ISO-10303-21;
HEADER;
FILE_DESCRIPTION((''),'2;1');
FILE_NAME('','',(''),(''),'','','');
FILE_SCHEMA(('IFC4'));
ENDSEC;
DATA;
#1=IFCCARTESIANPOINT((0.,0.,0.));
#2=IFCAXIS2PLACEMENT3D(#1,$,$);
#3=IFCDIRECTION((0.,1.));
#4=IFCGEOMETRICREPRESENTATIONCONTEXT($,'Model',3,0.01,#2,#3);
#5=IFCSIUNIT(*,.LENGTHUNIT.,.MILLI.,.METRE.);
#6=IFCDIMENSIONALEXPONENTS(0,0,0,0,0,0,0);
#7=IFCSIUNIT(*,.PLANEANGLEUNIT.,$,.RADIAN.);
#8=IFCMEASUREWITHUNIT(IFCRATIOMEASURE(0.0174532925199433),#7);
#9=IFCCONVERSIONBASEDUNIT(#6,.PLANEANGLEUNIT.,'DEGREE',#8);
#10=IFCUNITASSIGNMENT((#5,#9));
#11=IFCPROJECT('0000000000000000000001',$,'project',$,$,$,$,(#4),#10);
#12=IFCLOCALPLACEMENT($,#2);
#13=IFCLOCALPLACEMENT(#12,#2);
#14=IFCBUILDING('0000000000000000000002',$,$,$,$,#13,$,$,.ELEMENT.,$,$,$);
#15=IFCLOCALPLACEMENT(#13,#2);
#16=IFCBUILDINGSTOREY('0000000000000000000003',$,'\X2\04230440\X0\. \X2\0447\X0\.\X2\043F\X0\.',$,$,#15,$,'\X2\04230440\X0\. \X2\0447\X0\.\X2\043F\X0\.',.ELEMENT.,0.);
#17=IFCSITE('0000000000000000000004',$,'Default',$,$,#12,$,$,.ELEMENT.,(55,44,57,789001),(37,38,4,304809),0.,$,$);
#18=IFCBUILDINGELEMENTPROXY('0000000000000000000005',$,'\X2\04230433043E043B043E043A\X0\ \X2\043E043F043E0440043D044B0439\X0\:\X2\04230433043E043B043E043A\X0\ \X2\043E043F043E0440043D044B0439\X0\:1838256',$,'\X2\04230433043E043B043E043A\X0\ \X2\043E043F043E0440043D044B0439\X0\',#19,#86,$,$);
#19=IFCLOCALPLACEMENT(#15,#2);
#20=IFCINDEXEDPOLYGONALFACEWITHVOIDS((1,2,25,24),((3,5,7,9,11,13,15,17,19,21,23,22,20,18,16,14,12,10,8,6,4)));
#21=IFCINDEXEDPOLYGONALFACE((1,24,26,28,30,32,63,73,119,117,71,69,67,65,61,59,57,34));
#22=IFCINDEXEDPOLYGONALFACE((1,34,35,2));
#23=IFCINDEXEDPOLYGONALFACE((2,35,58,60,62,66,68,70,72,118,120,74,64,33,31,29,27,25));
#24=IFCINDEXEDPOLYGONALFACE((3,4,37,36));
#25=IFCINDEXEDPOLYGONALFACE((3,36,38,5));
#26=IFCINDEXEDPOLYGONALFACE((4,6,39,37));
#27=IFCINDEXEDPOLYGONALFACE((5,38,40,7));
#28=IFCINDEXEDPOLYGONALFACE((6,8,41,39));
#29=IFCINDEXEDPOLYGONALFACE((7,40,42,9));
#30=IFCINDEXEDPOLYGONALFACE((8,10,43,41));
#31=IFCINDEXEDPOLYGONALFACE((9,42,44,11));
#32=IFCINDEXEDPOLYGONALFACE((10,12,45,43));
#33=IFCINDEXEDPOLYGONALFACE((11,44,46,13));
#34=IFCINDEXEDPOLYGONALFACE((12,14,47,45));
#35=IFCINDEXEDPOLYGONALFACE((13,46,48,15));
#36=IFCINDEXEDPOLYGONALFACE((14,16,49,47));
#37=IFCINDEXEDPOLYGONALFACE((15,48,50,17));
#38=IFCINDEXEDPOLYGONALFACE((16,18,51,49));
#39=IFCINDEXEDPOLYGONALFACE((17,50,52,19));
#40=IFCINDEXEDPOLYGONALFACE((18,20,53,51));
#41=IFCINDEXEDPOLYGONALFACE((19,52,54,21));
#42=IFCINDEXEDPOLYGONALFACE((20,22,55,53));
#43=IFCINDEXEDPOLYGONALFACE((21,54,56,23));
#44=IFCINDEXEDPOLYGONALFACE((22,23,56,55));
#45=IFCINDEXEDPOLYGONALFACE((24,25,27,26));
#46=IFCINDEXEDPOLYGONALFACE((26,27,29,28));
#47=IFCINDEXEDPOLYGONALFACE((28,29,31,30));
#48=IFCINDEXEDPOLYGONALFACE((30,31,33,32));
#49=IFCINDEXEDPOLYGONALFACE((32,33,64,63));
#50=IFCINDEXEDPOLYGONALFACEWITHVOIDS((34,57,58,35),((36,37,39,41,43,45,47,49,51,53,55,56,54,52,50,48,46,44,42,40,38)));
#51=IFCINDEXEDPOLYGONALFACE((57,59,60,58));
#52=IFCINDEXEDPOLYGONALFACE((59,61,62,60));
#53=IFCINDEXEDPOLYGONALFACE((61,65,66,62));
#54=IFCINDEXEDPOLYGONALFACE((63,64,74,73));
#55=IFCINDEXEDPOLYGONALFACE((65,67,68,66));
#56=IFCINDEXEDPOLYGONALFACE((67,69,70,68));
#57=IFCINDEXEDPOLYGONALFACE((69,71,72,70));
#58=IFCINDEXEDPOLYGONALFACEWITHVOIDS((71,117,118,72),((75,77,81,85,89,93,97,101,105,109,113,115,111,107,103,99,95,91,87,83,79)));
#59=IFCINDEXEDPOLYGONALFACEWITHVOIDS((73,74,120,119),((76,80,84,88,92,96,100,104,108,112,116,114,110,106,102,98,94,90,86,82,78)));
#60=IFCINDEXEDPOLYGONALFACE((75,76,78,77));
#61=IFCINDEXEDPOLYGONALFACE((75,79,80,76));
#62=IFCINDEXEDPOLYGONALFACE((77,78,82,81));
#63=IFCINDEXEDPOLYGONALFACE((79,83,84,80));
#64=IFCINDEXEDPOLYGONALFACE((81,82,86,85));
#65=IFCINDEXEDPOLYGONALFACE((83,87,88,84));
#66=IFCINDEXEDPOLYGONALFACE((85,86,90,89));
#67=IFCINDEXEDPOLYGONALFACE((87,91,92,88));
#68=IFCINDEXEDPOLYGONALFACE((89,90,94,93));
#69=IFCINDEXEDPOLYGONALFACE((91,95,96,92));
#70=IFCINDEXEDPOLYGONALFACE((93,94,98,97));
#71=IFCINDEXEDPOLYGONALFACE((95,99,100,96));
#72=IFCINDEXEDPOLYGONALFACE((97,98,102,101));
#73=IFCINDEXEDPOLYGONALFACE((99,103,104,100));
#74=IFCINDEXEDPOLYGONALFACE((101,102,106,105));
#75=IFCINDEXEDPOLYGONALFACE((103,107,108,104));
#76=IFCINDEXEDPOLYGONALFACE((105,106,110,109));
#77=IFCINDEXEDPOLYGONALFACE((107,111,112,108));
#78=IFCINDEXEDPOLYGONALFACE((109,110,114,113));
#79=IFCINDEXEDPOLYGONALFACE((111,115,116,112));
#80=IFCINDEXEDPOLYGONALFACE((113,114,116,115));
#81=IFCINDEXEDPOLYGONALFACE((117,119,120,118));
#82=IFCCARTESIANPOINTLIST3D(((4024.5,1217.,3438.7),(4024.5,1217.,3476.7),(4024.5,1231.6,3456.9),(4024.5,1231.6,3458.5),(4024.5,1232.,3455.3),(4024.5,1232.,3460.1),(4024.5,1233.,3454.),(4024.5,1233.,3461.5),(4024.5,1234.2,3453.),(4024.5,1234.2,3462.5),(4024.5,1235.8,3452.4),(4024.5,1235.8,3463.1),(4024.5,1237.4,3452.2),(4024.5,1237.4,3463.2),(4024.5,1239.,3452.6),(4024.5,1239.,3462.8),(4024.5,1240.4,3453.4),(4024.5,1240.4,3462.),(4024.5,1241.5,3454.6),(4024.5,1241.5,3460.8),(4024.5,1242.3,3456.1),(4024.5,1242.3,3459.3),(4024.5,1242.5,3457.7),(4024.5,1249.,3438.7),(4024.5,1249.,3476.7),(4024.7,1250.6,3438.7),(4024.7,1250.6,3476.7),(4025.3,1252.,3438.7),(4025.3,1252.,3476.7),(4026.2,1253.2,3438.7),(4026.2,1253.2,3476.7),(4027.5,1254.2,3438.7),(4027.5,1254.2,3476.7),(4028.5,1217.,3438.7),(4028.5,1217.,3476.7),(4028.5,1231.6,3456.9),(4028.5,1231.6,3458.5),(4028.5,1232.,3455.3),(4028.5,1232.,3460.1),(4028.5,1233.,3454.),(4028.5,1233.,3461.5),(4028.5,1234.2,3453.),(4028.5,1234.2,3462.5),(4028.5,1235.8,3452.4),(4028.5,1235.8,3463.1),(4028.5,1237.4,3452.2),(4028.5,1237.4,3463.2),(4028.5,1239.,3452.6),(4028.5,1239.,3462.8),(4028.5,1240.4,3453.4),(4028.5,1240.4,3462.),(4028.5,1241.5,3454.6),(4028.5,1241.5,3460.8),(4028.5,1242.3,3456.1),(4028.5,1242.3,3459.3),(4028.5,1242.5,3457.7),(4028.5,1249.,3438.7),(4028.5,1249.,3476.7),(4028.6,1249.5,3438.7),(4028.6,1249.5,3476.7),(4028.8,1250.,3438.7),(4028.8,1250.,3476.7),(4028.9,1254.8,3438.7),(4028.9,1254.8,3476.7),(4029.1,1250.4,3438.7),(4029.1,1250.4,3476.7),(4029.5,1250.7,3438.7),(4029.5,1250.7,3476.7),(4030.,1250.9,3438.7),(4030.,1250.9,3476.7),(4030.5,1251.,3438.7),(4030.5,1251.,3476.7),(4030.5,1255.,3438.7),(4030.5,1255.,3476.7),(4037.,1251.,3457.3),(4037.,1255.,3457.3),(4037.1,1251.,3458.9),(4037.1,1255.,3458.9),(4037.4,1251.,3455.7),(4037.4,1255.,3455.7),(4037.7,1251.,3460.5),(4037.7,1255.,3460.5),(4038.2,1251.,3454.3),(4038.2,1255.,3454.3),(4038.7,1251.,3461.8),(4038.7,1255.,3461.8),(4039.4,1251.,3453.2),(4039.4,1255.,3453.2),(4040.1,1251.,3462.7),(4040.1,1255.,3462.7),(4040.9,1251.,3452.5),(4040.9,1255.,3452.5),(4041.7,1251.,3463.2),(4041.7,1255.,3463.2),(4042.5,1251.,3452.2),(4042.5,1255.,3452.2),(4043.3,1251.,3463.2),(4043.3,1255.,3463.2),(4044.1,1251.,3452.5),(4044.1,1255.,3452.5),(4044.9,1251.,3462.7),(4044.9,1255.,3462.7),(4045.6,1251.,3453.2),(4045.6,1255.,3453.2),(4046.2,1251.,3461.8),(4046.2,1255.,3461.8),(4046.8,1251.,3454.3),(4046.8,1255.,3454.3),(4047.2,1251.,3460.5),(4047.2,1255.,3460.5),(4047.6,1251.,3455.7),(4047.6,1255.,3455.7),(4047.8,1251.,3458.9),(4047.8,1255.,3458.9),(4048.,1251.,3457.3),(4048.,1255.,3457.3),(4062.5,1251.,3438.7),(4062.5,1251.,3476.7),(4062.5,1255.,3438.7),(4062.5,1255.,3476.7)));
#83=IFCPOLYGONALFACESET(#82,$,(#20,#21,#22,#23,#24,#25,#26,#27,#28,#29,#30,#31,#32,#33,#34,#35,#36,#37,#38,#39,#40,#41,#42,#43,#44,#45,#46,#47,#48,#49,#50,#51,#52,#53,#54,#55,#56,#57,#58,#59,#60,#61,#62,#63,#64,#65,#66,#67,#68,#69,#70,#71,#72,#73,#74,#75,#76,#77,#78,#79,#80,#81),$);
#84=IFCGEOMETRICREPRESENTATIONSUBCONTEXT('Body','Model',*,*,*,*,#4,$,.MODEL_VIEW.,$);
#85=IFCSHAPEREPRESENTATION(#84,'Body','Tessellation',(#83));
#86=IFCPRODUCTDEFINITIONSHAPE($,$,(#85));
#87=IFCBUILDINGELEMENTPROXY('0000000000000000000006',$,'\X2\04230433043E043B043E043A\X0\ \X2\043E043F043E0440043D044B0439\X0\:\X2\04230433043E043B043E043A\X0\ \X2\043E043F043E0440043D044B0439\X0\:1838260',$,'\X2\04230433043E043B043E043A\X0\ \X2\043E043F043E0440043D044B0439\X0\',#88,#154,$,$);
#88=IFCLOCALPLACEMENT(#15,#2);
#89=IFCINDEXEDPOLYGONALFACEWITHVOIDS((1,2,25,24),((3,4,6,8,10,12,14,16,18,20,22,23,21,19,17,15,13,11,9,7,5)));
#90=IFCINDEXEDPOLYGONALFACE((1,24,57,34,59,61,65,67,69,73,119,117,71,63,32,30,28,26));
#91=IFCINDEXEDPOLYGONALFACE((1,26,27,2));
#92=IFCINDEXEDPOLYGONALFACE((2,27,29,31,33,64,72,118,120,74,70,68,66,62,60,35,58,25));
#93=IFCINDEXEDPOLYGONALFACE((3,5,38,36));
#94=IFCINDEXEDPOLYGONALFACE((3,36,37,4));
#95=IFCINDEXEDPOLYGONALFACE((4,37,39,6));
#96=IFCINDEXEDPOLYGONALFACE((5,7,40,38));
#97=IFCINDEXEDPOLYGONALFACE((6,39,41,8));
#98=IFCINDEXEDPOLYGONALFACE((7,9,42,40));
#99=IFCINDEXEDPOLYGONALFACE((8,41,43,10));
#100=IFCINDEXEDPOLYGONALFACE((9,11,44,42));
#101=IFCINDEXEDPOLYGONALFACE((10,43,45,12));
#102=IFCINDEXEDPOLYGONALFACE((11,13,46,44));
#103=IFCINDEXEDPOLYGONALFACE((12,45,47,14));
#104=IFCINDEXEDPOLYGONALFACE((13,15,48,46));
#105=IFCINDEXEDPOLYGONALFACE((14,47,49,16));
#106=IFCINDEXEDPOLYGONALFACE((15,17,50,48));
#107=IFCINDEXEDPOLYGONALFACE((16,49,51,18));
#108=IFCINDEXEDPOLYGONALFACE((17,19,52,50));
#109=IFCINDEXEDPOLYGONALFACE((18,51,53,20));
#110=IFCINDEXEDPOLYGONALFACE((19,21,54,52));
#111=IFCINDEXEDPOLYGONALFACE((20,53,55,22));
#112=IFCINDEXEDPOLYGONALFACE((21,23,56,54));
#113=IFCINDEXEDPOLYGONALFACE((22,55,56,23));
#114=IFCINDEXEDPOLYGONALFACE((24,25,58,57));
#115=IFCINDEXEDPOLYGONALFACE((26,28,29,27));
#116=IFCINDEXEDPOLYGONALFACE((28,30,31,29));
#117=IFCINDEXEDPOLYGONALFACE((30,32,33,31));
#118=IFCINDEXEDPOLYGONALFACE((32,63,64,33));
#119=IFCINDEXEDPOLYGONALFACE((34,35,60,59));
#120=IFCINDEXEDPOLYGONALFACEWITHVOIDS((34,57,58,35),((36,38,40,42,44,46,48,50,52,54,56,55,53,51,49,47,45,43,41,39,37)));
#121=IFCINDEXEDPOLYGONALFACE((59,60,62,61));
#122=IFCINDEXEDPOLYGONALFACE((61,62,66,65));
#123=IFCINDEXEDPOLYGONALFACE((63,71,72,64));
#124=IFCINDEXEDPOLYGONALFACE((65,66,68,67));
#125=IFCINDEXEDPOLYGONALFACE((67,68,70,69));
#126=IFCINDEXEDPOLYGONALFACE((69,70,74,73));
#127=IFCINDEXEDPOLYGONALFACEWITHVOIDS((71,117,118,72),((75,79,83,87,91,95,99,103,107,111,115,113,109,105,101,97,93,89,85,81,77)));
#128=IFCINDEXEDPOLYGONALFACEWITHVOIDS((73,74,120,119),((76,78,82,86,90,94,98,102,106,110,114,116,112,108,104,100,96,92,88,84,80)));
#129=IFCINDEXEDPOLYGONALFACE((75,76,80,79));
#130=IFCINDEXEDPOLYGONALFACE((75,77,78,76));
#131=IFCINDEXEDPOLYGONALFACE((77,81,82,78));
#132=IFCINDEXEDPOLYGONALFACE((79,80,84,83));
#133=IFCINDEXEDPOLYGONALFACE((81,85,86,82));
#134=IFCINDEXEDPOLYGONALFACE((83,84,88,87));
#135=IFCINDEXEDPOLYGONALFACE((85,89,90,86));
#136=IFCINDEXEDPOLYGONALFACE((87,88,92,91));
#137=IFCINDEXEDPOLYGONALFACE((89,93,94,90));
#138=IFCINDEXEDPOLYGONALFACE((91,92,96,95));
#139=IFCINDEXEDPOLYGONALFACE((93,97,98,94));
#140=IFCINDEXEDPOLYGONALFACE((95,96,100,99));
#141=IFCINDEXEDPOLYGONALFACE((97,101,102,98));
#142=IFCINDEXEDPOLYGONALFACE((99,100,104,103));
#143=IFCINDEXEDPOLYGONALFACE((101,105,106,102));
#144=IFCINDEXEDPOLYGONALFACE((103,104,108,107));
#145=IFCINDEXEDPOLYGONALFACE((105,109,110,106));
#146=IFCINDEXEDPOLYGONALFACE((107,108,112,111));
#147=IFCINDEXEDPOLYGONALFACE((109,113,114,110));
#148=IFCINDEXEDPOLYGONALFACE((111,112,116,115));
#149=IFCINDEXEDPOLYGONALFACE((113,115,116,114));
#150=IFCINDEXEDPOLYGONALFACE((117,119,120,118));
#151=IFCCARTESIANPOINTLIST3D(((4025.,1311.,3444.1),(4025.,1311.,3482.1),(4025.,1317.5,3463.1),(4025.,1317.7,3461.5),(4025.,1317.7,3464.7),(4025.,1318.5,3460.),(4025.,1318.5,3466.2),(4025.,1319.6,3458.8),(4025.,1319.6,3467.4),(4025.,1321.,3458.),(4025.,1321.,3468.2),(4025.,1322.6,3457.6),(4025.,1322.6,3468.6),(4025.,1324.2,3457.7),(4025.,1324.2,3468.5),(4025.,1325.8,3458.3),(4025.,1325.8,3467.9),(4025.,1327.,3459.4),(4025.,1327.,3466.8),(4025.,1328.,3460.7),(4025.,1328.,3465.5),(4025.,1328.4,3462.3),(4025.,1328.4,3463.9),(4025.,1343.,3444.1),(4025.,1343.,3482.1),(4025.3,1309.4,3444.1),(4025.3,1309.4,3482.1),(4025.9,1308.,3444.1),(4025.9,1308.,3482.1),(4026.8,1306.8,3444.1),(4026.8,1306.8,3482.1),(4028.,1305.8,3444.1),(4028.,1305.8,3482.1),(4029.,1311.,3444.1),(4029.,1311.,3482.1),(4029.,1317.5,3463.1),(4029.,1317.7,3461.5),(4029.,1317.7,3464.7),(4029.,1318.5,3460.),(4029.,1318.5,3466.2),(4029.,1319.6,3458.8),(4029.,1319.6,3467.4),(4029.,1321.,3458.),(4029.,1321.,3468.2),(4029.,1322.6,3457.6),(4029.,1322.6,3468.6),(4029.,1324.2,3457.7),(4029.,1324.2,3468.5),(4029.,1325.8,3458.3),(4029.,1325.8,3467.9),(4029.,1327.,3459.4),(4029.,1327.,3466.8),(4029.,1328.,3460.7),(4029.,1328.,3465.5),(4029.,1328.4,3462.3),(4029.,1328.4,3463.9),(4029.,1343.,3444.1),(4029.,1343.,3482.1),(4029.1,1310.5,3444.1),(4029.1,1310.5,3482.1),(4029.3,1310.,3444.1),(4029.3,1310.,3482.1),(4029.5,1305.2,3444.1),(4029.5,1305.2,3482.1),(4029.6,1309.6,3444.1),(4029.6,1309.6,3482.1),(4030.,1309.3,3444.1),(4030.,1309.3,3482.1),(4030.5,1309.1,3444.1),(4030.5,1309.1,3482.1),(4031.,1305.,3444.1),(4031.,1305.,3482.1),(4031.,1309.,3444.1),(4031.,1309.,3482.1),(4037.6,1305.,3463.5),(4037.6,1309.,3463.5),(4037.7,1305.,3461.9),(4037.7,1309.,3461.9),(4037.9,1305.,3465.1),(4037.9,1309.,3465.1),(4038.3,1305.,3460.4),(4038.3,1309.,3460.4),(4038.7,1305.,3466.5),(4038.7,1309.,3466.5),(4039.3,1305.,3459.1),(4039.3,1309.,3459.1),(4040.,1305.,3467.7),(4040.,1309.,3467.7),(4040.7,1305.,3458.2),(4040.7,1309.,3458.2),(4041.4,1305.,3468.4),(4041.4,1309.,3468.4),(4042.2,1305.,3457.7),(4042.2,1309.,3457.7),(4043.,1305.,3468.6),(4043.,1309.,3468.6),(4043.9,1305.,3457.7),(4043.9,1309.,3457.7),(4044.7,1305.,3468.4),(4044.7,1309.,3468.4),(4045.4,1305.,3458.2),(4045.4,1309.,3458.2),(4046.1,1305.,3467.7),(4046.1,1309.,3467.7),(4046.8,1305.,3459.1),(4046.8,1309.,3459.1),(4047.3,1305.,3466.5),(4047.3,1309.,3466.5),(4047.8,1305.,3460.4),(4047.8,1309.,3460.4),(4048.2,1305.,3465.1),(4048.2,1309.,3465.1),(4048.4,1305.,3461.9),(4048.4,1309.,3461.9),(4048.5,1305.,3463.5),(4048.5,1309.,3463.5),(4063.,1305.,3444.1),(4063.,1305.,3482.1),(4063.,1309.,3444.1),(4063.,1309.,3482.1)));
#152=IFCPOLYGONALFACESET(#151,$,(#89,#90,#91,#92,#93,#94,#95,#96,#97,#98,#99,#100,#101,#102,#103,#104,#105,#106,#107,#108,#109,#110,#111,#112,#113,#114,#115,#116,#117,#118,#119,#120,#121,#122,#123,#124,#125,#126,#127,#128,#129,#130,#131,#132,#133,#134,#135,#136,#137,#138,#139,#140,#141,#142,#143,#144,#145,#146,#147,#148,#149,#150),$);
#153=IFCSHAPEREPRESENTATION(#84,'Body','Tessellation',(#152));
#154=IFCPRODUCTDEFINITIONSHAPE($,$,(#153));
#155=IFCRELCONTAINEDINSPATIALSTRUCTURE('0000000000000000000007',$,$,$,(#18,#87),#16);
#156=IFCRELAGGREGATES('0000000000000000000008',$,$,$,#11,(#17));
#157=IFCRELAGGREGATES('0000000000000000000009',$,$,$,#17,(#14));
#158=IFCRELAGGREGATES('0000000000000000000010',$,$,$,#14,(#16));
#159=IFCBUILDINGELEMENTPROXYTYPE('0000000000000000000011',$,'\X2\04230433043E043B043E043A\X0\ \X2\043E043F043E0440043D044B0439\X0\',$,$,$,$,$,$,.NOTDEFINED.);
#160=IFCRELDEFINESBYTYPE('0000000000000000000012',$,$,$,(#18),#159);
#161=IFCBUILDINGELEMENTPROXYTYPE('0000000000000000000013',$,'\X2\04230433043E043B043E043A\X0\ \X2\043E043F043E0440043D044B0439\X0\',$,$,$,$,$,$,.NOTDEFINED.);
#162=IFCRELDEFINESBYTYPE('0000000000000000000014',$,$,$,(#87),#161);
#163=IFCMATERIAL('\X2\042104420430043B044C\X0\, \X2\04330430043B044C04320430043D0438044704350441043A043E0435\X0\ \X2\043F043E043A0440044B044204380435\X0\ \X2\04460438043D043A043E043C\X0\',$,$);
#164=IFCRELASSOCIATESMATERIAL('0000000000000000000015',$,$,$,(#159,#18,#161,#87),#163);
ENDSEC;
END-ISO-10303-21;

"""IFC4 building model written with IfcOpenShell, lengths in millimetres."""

from ifc_helpers import new_model, entity, si_unit, converted_unit, direction, frame, frame_2d, origin, place, context, subcontext, project, spatial, polyline, circle_curve, parameter, trimmed, segment, composite_curve, circle, outline, extrude, source, transform, mapped, material, type_object, type_shapes, element, save


model = new_model("IFC4")

# Units and contexts
model_context = context("Model", 3, precision=0.01, world=origin(), true_north=direction((0.0, 1.0)))
body_context = subcontext(model_context, "Body", "Model", "MODEL_VIEW")
ifc_project = project(units=[si_unit("LENGTHUNIT", "METRE", prefix="MILLI"), converted_unit("PLANEANGLEUNIT", "DEGREE", entity("IfcRatioMeasure", 0.0174532925199433), si_unit("PLANEANGLEUNIT", "RADIAN"), dimensions=[0, 0, 0, 0, 0, 0, 0])], contexts=[model_context])

# Site, building, storey
site_placement = place(None, origin())
site = spatial("IfcSite", under=ifc_project, at=site_placement, Name="Default", CompositionType="ELEMENT", RefLatitude=(55, 44, 57, 789001), RefLongitude=(37, 38, 4, 304809), RefElevation=0.0)
building_placement = place(site_placement, origin())
building = spatial("IfcBuilding", under=site, at=building_placement, CompositionType="ELEMENT")
storey_placement = place(building_placement, origin())
storey = spatial("IfcBuildingStorey", under=building, at=storey_placement, Name="Ур. ч.п.", LongName="Ур. ч.п.", CompositionType="ELEMENT", Elevation=0.0)

# Building element proxies, openings
ifc_material = material(Name="Сталь, гальваническое покрытие цинком")
building_element_proxy_type_1 = type_object("IfcBuildingElementProxyType", Name="Уголок опорный", material=ifc_material)
shared_shape_1 = source(origin(), body_context, "Body", "SweptSolid", [
    extrude(outline(composite_curve([segment(polyline([(-6.0, -12.0), (26.0, -12.0)]), True, "CONTINUOUS"), segment(polyline([(26.0, -12.0), (26.0, -8.0)]), True, "CONTINUOUS"), segment(polyline([(26.0, -8.0), (-6.0, -8.0)]), True, "CONTINUOUS"), segment(trimmed(circle_curve(frame_2d((-6.0, -6.0), x_axis=(0.0, -1.0)), 2.0), [parameter(270.0)], [parameter(0.0)], True, "PARAMETER"), False, "CONTINUOUS"), segment(polyline([(-8.0, -6.0), (-8.0, 26.0)]), True, "CONTINUOUS"), segment(polyline([(-8.0, 26.0), (-12.0, 26.0)]), True, "CONTINUOUS"), segment(polyline([(-12.0, 26.0), (-12.0, -6.0)]), True, "CONTINUOUS"), segment(trimmed(circle_curve(frame_2d((-6.0, -6.0), x_axis=(0.0, -1.0)), 6.0), [parameter(270.0)], [parameter(360.0)], True, "PARAMETER"), True, "CONTINUOUS")], self_intersect=False)), frame((12.0, -19.0, 12.0), z_axis=(0.0, 1.0, 0.0), x_axis=(0.0, 0.0, 1.0)), (0.0, 0.0, 1.0), 38.0),
])
type_shapes(building_element_proxy_type_1, [shared_shape_1])
proxy_1_placement = place(storey_placement, frame((4024.5, 1255.0, 3457.7), z_axis=(0.0, -1.0, 0.0), x_axis=(1.0, 0.0, 0.0)))
proxy_1 = element("IfcBuildingElementProxy", 1, at=proxy_1_placement, inside=storey, type_object=building_element_proxy_type_1, material=ifc_material, Name="Уголок опорный:Уголок опорный:1838256", ObjectType="Уголок опорный", context=body_context, shape_type="MappedRepresentation", body=[
    mapped(shared_shape_1, transform((0.0, 0.0, 0.0), scale=1.0)),
])
opening_1_placement = place(storey_placement, frame((4024.5, 1255.0, 3457.7), z_axis=(0.0, 0.0, -1.0), x_axis=(1.0, 0.0, 0.0)))
element("IfcOpeningElement", 2, at=opening_1_placement, cuts=proxy_1, ObjectType="Opening", PredefinedType="OPENING", context=body_context, shape_type="SweptSolid", body=[
    extrude(circle(Radius=5.5, at=frame_2d((0.0, 0.0), x_axis=(1.0, 0.0))), frame((0.0, 18.0, 0.0), z_axis=(1.0, 0.0, 0.0), x_axis=(0.0, -1.0, 0.0)), (0.0, 0.0, 1.0), 4.0),
])
opening_2_placement = place(storey_placement, frame((4024.5, 1255.0, 3457.7), z_axis=(0.0, 0.0, -1.0), x_axis=(1.0, 0.0, 0.0)))
element("IfcOpeningElement", 3, at=opening_2_placement, cuts=proxy_1, ObjectType="Opening", PredefinedType="OPENING", context=body_context, shape_type="SweptSolid", body=[
    extrude(circle(Radius=5.5, at=frame_2d((0.0, 0.0), x_axis=(1.0, 0.0))), frame((18.0, 0.0, 0.0), z_axis=(0.0, 1.0, 0.0), x_axis=(0.0, 0.0, 1.0)), (0.0, 0.0, 1.0), 4.0),
])
building_element_proxy_type_2 = type_object("IfcBuildingElementProxyType", Name="Уголок опорный", material=ifc_material)
shared_shape_2 = source(origin(), body_context, "Body", "SweptSolid", [
    extrude(outline(composite_curve([segment(polyline([(-6.0, -12.0), (26.0, -12.0)]), True, "CONTINUOUS"), segment(polyline([(26.0, -12.0), (26.0, -8.0)]), True, "CONTINUOUS"), segment(polyline([(26.0, -8.0), (-6.0, -8.0)]), True, "CONTINUOUS"), segment(trimmed(circle_curve(frame_2d((-6.0, -6.0), x_axis=(0.0, -1.0)), 2.0), [parameter(270.0)], [parameter(0.0)], True, "PARAMETER"), False, "CONTINUOUS"), segment(polyline([(-8.0, -6.0), (-8.0, 26.0)]), True, "CONTINUOUS"), segment(polyline([(-8.0, 26.0), (-12.0, 26.0)]), True, "CONTINUOUS"), segment(polyline([(-12.0, 26.0), (-12.0, -6.0)]), True, "CONTINUOUS"), segment(trimmed(circle_curve(frame_2d((-6.0, -6.0), x_axis=(0.0, -1.0)), 6.0), [parameter(270.0)], [parameter(360.0)], True, "PARAMETER"), True, "CONTINUOUS")], self_intersect=False)), frame((12.0, -19.0, 12.0), z_axis=(0.0, 1.0, 0.0), x_axis=(0.0, 0.0, 1.0)), (0.0, 0.0, 1.0), 38.0),
])
type_shapes(building_element_proxy_type_2, [shared_shape_2])
proxy_2_placement = place(storey_placement, frame((4025.0, 1305.0, 3463.1), z_axis=(0.0, 1.0, 0.0), x_axis=(1.0, 0.0, 0.0)))
proxy_2 = element("IfcBuildingElementProxy", 4, at=proxy_2_placement, inside=storey, type_object=building_element_proxy_type_2, material=ifc_material, Name="Уголок опорный:Уголок опорный:1838260", ObjectType="Уголок опорный", context=body_context, shape_type="MappedRepresentation", body=[
    mapped(shared_shape_2, transform((0.0, 0.0, 0.0), scale=1.0)),
])
opening_3_placement = place(storey_placement, frame((4025.0, 1305.0, 3463.1), z_axis=(0.0, 0.0, -1.0), x_axis=(1.0, 0.0, 0.0)))
element("IfcOpeningElement", 5, at=opening_3_placement, cuts=proxy_2, ObjectType="Opening", PredefinedType="OPENING", context=body_context, shape_type="SweptSolid", body=[
    extrude(circle(Radius=5.5, at=frame_2d((0.0, 0.0), x_axis=(1.0, 0.0))), frame((4.0, -18.0, 0.0), z_axis=(-1.0, 0.0, 0.0), x_axis=(0.0, 1.0, 0.0)), (0.0, 0.0, 1.0), 4.0),
])
opening_4_placement = place(storey_placement, frame((4025.0, 1305.0, 3463.1), z_axis=(0.0, 0.0, -1.0), x_axis=(1.0, 0.0, 0.0)))
element("IfcOpeningElement", 6, at=opening_4_placement, cuts=proxy_2, ObjectType="Opening", PredefinedType="OPENING", context=body_context, shape_type="SweptSolid", body=[
    extrude(circle(Radius=5.5, at=frame_2d((0.0, 0.0), x_axis=(1.0, 0.0))), frame((18.0, 0.0, 0.0), z_axis=(0.0, -1.0, 0.0), x_axis=(0.0, 0.0, -1.0)), (0.0, 0.0, 1.0), 4.0),
])

save(model, "model.ifc")
